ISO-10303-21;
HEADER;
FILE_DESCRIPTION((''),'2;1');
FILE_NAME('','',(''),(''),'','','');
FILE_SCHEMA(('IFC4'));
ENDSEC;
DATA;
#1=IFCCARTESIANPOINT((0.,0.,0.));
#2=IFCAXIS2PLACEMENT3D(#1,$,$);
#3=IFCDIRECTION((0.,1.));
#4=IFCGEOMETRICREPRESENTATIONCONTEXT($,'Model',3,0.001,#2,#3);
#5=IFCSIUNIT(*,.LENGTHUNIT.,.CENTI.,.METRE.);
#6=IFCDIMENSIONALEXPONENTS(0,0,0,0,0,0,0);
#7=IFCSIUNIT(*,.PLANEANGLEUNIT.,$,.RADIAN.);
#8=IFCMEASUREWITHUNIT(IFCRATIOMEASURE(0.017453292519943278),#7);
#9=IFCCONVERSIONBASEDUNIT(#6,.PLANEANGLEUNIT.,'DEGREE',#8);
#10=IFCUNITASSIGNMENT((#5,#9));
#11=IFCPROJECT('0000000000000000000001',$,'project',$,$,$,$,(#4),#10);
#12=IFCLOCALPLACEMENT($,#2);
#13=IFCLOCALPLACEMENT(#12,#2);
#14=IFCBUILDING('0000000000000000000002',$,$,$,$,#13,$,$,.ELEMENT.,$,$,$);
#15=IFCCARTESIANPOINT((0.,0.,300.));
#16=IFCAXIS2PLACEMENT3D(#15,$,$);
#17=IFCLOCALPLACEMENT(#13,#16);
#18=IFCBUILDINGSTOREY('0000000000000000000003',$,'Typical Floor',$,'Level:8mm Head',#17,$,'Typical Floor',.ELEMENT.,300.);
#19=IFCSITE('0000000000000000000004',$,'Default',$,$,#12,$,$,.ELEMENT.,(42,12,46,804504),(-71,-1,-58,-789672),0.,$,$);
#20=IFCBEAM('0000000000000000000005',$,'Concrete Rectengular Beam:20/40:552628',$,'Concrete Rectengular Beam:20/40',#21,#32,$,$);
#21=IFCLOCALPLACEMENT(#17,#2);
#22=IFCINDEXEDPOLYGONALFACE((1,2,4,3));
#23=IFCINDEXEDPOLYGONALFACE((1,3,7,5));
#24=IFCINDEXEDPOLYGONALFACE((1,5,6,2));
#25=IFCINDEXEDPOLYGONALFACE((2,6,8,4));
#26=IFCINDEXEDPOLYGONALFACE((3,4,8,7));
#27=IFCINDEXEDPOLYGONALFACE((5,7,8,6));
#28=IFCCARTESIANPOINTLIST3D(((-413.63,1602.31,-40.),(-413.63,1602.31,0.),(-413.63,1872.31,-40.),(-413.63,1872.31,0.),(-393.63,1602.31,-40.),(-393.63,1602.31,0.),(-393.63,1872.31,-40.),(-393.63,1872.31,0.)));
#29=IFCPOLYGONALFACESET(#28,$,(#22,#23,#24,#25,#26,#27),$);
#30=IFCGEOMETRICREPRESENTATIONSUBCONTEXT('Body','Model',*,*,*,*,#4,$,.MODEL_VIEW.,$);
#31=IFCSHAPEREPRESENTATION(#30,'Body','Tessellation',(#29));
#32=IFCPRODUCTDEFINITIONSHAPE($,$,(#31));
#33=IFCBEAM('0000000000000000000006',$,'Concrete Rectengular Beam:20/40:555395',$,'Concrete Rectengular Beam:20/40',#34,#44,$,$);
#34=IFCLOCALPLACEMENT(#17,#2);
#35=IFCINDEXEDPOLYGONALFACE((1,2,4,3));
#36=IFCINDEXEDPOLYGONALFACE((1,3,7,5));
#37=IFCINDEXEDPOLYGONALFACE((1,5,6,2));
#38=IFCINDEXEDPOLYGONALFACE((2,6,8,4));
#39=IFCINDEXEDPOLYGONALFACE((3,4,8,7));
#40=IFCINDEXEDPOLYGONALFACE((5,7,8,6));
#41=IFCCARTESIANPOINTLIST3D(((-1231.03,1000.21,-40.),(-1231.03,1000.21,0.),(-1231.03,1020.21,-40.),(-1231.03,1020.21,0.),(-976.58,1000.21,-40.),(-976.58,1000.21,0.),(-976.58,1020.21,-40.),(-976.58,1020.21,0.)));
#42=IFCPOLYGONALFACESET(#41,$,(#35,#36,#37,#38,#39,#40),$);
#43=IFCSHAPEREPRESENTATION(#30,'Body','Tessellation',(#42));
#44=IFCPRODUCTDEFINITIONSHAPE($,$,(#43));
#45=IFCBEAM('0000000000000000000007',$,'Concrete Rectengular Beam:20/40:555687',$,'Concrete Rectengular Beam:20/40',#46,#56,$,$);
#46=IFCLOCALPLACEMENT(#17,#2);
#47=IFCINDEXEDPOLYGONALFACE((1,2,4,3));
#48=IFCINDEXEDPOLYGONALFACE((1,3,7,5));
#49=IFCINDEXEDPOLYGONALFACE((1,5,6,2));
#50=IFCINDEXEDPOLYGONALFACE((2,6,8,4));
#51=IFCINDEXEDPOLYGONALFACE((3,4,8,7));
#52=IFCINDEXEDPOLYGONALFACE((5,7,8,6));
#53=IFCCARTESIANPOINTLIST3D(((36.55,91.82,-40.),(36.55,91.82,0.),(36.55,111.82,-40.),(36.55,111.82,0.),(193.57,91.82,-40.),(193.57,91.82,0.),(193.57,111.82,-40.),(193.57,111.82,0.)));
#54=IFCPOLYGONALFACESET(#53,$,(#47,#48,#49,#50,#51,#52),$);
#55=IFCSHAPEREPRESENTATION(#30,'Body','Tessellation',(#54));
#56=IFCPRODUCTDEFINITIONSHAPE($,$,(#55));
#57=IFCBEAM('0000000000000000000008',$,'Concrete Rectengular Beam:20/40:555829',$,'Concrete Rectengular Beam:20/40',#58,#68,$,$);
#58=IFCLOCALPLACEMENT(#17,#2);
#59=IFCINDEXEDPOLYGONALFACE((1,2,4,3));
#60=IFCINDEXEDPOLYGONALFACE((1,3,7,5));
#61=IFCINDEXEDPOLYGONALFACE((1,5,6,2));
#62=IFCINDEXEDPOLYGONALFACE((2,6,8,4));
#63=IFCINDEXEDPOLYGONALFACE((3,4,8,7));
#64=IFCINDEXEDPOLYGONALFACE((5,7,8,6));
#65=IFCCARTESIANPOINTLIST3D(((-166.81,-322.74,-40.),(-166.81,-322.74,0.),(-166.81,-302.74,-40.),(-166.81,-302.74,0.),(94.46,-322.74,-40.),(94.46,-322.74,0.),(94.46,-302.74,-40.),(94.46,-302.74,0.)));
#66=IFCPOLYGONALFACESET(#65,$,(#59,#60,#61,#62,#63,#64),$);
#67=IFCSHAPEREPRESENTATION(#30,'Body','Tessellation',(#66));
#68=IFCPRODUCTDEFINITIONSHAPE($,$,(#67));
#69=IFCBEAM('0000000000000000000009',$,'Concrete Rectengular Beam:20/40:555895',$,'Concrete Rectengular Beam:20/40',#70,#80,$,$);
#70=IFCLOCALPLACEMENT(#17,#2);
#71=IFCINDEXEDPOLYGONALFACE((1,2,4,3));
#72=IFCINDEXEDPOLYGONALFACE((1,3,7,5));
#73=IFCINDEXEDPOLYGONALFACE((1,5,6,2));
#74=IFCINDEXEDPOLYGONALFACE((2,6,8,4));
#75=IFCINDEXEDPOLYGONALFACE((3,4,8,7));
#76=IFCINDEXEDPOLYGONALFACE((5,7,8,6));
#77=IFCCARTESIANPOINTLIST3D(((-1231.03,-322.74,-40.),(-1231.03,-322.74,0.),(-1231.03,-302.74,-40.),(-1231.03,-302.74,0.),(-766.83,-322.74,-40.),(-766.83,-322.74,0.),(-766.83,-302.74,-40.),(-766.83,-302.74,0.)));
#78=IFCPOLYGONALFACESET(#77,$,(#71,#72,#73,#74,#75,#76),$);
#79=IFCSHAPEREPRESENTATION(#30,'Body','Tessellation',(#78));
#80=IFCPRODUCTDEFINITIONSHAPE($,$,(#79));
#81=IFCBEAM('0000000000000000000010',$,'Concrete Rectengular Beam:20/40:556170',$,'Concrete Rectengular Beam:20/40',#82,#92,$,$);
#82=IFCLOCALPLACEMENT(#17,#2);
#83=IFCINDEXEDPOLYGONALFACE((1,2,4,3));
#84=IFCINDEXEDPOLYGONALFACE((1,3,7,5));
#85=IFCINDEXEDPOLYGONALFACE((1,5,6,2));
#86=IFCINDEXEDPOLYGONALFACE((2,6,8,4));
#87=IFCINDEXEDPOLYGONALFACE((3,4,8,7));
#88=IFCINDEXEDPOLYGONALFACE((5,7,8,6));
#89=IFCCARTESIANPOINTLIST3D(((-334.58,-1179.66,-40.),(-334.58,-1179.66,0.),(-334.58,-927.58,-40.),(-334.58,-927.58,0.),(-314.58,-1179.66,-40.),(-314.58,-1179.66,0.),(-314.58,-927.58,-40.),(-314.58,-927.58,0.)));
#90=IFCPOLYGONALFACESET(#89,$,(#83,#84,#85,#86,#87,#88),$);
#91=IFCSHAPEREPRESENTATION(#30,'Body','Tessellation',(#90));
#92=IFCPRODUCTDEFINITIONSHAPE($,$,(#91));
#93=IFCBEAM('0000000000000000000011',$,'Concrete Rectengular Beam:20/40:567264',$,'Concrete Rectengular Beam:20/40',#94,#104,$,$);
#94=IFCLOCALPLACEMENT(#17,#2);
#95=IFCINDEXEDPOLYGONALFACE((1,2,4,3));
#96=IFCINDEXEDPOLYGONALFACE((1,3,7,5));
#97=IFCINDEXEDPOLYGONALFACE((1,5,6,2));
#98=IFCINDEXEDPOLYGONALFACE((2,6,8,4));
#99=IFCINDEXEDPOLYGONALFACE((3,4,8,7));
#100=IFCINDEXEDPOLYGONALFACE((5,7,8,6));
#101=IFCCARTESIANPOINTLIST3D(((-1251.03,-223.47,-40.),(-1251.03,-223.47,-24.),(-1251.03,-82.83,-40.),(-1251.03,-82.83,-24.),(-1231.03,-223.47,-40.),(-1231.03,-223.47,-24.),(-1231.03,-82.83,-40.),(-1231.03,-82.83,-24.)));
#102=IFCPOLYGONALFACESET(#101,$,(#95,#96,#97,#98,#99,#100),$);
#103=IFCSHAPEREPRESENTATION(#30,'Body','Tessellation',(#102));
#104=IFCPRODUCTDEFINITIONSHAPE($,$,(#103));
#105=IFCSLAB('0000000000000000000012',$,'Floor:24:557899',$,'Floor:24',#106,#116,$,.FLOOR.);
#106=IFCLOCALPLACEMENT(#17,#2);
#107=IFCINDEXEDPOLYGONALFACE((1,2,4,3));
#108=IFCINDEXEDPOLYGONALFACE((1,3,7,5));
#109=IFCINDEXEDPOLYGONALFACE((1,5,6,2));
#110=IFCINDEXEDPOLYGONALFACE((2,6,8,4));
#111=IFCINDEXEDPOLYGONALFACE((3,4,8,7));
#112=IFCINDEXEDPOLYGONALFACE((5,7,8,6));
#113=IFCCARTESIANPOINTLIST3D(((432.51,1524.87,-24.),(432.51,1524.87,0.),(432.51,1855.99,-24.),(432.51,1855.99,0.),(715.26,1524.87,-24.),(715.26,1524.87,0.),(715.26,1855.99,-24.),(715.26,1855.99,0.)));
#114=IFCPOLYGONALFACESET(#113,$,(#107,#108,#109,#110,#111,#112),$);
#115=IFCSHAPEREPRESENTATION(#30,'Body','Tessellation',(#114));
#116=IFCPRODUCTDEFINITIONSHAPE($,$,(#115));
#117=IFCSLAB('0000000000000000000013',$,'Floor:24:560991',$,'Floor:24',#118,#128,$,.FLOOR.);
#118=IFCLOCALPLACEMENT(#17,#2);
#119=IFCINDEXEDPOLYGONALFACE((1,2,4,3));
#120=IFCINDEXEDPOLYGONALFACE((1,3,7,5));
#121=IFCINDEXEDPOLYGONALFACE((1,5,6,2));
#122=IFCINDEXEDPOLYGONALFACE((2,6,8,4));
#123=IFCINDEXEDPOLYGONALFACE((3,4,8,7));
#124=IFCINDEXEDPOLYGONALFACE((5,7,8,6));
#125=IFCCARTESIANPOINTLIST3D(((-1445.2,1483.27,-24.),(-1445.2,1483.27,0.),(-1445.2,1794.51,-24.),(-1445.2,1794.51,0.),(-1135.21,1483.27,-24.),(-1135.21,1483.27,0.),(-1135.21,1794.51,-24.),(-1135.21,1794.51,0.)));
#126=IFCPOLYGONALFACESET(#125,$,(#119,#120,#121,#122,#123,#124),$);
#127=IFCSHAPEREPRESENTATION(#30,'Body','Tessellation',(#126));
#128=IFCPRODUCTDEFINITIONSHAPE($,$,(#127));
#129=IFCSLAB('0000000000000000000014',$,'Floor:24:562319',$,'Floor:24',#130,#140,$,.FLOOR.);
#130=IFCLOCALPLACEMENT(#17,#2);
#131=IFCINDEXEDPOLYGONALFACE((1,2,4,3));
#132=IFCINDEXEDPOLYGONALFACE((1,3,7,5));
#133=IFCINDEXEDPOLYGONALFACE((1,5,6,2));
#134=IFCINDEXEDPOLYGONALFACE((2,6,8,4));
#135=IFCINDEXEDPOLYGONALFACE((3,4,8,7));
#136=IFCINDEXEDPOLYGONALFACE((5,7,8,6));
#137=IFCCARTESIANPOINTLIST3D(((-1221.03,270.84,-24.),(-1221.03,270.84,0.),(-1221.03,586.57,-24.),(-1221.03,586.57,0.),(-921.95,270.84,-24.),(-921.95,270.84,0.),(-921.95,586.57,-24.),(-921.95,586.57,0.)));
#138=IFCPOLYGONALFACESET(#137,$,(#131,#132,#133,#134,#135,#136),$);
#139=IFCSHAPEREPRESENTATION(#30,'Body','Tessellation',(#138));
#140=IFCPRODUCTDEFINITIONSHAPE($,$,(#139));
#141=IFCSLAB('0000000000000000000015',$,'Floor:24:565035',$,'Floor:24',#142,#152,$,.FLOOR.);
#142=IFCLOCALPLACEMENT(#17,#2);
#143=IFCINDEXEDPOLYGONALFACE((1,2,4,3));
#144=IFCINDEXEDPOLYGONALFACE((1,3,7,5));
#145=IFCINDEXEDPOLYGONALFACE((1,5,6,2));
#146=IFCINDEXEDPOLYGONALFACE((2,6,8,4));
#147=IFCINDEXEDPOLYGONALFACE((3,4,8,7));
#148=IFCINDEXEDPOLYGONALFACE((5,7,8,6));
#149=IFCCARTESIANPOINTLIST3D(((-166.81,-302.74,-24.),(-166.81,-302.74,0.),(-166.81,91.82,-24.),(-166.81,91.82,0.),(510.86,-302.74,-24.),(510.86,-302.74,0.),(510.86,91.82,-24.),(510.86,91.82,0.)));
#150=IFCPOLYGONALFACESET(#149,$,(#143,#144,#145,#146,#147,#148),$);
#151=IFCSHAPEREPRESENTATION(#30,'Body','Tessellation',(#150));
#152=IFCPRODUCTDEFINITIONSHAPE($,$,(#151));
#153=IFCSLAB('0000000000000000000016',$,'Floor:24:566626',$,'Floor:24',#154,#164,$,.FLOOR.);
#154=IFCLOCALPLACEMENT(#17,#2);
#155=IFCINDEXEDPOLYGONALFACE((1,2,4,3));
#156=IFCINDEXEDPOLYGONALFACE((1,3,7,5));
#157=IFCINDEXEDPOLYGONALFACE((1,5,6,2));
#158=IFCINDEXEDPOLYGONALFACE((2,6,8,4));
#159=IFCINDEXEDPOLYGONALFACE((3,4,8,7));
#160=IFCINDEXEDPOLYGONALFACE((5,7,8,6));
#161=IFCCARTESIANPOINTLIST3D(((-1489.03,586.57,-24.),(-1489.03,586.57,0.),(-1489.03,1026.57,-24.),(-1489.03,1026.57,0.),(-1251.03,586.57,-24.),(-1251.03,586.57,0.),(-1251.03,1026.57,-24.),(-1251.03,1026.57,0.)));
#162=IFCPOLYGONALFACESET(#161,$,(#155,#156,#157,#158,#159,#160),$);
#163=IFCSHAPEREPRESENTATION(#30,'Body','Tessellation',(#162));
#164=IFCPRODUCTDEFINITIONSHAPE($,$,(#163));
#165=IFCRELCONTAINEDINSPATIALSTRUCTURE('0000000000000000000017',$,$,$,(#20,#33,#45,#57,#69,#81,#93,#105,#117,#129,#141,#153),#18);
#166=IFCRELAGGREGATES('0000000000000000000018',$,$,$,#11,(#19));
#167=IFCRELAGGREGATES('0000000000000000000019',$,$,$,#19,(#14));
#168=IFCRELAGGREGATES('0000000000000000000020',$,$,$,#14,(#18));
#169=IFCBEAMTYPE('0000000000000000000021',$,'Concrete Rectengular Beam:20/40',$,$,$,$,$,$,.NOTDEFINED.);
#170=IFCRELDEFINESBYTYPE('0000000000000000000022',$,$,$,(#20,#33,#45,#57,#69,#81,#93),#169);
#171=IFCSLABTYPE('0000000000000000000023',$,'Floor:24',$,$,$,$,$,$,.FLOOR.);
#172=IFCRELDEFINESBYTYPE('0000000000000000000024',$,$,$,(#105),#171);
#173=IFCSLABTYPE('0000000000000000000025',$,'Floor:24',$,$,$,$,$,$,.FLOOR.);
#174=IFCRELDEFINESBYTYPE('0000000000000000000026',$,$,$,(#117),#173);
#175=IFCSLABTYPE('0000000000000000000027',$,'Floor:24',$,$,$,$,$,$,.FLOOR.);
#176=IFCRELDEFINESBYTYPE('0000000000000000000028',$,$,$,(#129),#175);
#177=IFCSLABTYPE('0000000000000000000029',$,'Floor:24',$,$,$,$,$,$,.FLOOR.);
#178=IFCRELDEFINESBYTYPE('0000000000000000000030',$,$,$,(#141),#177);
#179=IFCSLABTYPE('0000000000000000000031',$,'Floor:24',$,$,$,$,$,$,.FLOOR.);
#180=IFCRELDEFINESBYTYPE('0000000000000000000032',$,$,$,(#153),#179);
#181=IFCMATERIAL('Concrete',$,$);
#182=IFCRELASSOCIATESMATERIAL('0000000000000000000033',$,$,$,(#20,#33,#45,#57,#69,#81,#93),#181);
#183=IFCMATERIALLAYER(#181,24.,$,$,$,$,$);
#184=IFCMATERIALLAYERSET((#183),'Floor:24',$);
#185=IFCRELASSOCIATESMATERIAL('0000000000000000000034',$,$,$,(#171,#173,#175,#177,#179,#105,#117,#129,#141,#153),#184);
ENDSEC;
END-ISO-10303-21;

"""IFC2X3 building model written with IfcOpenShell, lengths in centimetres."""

from ifc_helpers import new_model, entity, si_unit, converted_unit, direction, frame, frame_2d, origin, origin_2d_with_axis, place, context, subcontext, project, spatial, rectangle, extrude, material, layer, layer_set, layer_usage, type_object, element, save


model = new_model("IFC2X3")

# Units and contexts
model_context = context("Model", 3, precision=0.001, world=origin(), true_north=direction((0.0, 1.0)))
body_context = subcontext(model_context, "Body", "Model", "MODEL_VIEW")
ifc_project = project(units=[si_unit("LENGTHUNIT", "METRE", prefix="CENTI"), converted_unit("PLANEANGLEUNIT", "DEGREE", entity("IfcRatioMeasure", 0.017453292519943278), si_unit("PLANEANGLEUNIT", "RADIAN"), dimensions=[0, 0, 0, 0, 0, 0, 0])], contexts=[model_context])

# Site, building, storey
site_placement = place(None, origin())
site = spatial("IfcSite", under=ifc_project, at=site_placement, Name="Default", CompositionType="ELEMENT", RefLatitude=(42, 12, 46, 804504), RefLongitude=(-71, -1, -58, -789672), RefElevation=0.0)
building_placement = place(site_placement, origin())
building = spatial("IfcBuilding", under=site, at=building_placement, CompositionType="ELEMENT")
storey_placement = place(building_placement, frame((0.0, 0.0, 300.0)))
storey = spatial("IfcBuildingStorey", under=building, at=storey_placement, Name="Typical Floor", ObjectType="Level:8mm Head", LongName="Typical Floor", CompositionType="ELEMENT", Elevation=300.0)

# Beams
ifc_material = material(Name="Concrete")
beam_type = type_object("IfcBeamType", Name="Concrete Rectengular Beam:20/40", PredefinedType="NOTDEFINED")
beam_1_placement = place(storey_placement, frame((-403.63, 1882.31, 0.0), z_axis=(0.0, 0.0, 1.0), x_axis=(0.0, -1.0, 0.0)))
element("IfcBeam", 1, at=beam_1_placement, inside=storey, type_object=beam_type, material=ifc_material, Name="Concrete Rectengular Beam:20/40:552628", ObjectType="Concrete Rectengular Beam:20/40", context=body_context, shape_type="SweptSolid", body=[
    extrude(rectangle(XDim=40.0, YDim=20.0, at=origin_2d_with_axis()), frame((10.0, 0.0, -20.0), z_axis=(1.0, 0.0, 0.0), x_axis=(0.0, 0.0, -1.0)), (0.0, 0.0, 1.0), 270.0),
])
beam_2_placement = place(storey_placement, frame((-1241.03, 1010.21, 0.0)))
element("IfcBeam", 2, at=beam_2_placement, inside=storey, type_object=beam_type, material=ifc_material, Name="Concrete Rectengular Beam:20/40:555395", ObjectType="Concrete Rectengular Beam:20/40", context=body_context, shape_type="SweptSolid", body=[
    extrude(rectangle(XDim=40.0, YDim=20.0, at=frame_2d((0.0, 0.0), x_axis=(1.0, 0.0))), frame((10.0, 0.0, -20.0), z_axis=(1.0, 0.0, 0.0), x_axis=(0.0, 0.0, -1.0)), (0.0, 0.0, 1.0), 254.45),
])
beam_3_placement = place(storey_placement, frame((26.55, 101.82, 0.0)))
element("IfcBeam", 3, at=beam_3_placement, inside=storey, type_object=beam_type, material=ifc_material, Name="Concrete Rectengular Beam:20/40:555687", ObjectType="Concrete Rectengular Beam:20/40", context=body_context, shape_type="SweptSolid", body=[
    extrude(rectangle(XDim=40.0, YDim=20.0, at=frame_2d((0.0, 0.0), x_axis=(1.0, 0.0))), frame((10.0, 0.0, -20.0), z_axis=(1.0, 0.0, 0.0), x_axis=(0.0, 0.0, -1.0)), (0.0, 0.0, 1.0), 157.01),
])
beam_4_placement = place(storey_placement, frame((-176.81, -312.74, 0.0)))
element("IfcBeam", 4, at=beam_4_placement, inside=storey, type_object=beam_type, material=ifc_material, Name="Concrete Rectengular Beam:20/40:555829", ObjectType="Concrete Rectengular Beam:20/40", context=body_context, shape_type="SweptSolid", body=[
    extrude(rectangle(XDim=40.0, YDim=20.0, at=frame_2d((0.0, 0.0), x_axis=(1.0, 0.0))), frame((10.0, 0.0, -20.0), z_axis=(1.0, 0.0, 0.0), x_axis=(0.0, 0.0, -1.0)), (0.0, 0.0, 1.0), 261.28),
])
beam_5_placement = place(storey_placement, frame((-1241.03, -312.74, 0.0)))
element("IfcBeam", 5, at=beam_5_placement, inside=storey, type_object=beam_type, material=ifc_material, Name="Concrete Rectengular Beam:20/40:555895", ObjectType="Concrete Rectengular Beam:20/40", context=body_context, shape_type="SweptSolid", body=[
    extrude(rectangle(XDim=40.0, YDim=20.0, at=frame_2d((0.0, 0.0), x_axis=(1.0, 0.0))), frame((10.0, 0.0, -20.0), z_axis=(1.0, 0.0, 0.0), x_axis=(0.0, 0.0, -1.0)), (0.0, 0.0, 1.0), 464.2),
])
beam_6_placement = place(storey_placement, frame((-324.58, -1189.66, 0.0), z_axis=(0.0, 0.0, 1.0), x_axis=(0.0, 1.0, 0.0)))
element("IfcBeam", 6, at=beam_6_placement, inside=storey, type_object=beam_type, material=ifc_material, Name="Concrete Rectengular Beam:20/40:556170", ObjectType="Concrete Rectengular Beam:20/40", context=body_context, shape_type="SweptSolid", body=[
    extrude(rectangle(XDim=40.0, YDim=20.0, at=origin_2d_with_axis()), frame((10.0, 0.0, -20.0), z_axis=(1.0, 0.0, 0.0), x_axis=(0.0, 0.0, -1.0)), (0.0, 0.0, 1.0), 252.08),
])
beam_7_placement = place(storey_placement, frame((-1241.03, -233.47, 0.0), z_axis=(0.0, 0.0, 1.0), x_axis=(0.0, 1.0, 0.0)))
element("IfcBeam", 7, at=beam_7_placement, inside=storey, type_object=beam_type, material=ifc_material, Name="Concrete Rectengular Beam:20/40:567264", ObjectType="Concrete Rectengular Beam:20/40", context=body_context, shape_type="SweptSolid", body=[
    extrude(rectangle(XDim=16.0, YDim=20.0, at=frame_2d((0.0, 0.0), x_axis=(1.0, 0.0))), frame((10.0, 0.0, -32.0), z_axis=(1.0, 0.0, 0.0), x_axis=(0.0, 0.0, -1.0)), (0.0, 0.0, 1.0), 140.64),
])

# Slabs
ifc_layer = layer(ifc_material, 24.0)
ifc_layer_set = layer_set([ifc_layer], Name="Floor:24")
ifc_layer_usage_1 = layer_usage(ifc_layer_set, "AXIS3", "POSITIVE", 0.0)
slab_type_1 = type_object("IfcSlabType", Name="Floor:24", PredefinedType="FLOOR", material=ifc_layer_set)
slab_1_placement = place(storey_placement, origin())
element("IfcSlab", 8, at=slab_1_placement, inside=storey, type_object=slab_type_1, material=ifc_layer_usage_1, Name="Floor:24:557899", ObjectType="Floor:24", PredefinedType="FLOOR", context=body_context, shape_type="SweptSolid", body=[
    extrude(rectangle(XDim=331.12, YDim=282.75, at=frame_2d((0.0, 0.0), x_axis=(1.0, 0.0))), frame((573.88, 1690.43, 0.0), z_axis=(0.0, 0.0, -1.0), x_axis=(0.0, 1.0, 0.0)), (0.0, 0.0, 1.0), 24.0),
])
ifc_layer_usage_2 = layer_usage(ifc_layer_set, "AXIS3", "POSITIVE", 0.0)
slab_type_2 = type_object("IfcSlabType", Name="Floor:24", PredefinedType="FLOOR", material=ifc_layer_set)
slab_2_placement = place(storey_placement, origin())
element("IfcSlab", 9, at=slab_2_placement, inside=storey, type_object=slab_type_2, material=ifc_layer_usage_2, Name="Floor:24:560991", ObjectType="Floor:24", PredefinedType="FLOOR", context=body_context, shape_type="SweptSolid", body=[
    extrude(rectangle(XDim=311.25, YDim=309.99, at=frame_2d((0.0, 0.0), x_axis=(1.0, 0.0))), frame((-1290.2, 1638.89, 0.0), z_axis=(0.0, 0.0, -1.0), x_axis=(0.0, 1.0, 0.0)), (0.0, 0.0, 1.0), 24.0),
])
ifc_layer_usage_3 = layer_usage(ifc_layer_set, "AXIS3", "POSITIVE", 0.0)
slab_type_3 = type_object("IfcSlabType", Name="Floor:24", PredefinedType="FLOOR", material=ifc_layer_set)
slab_3_placement = place(storey_placement, origin())
element("IfcSlab", 10, at=slab_3_placement, inside=storey, type_object=slab_type_3, material=ifc_layer_usage_3, Name="Floor:24:562319", ObjectType="Floor:24", PredefinedType="FLOOR", context=body_context, shape_type="SweptSolid", body=[
    extrude(rectangle(XDim=315.73, YDim=299.07, at=frame_2d((0.0, 0.0), x_axis=(1.0, 0.0))), frame((-1071.49, 428.71, 0.0), z_axis=(0.0, 0.0, -1.0), x_axis=(0.0, 1.0, 0.0)), (0.0, 0.0, 1.0), 24.0),
])
ifc_layer_usage_4 = layer_usage(ifc_layer_set, "AXIS3", "POSITIVE", 0.0)
slab_type_4 = type_object("IfcSlabType", Name="Floor:24", PredefinedType="FLOOR", material=ifc_layer_set)
slab_4_placement = place(storey_placement, origin())
element("IfcSlab", 11, at=slab_4_placement, inside=storey, type_object=slab_type_4, material=ifc_layer_usage_4, Name="Floor:24:565035", ObjectType="Floor:24", PredefinedType="FLOOR", context=body_context, shape_type="SweptSolid", body=[
    extrude(rectangle(XDim=394.56, YDim=677.67, at=origin_2d_with_axis()), frame((172.02, -105.46, 0.0), z_axis=(0.0, 0.0, -1.0), x_axis=(0.0, 1.0, 0.0)), (0.0, 0.0, 1.0), 24.0),
])
ifc_layer_usage_5 = layer_usage(ifc_layer_set, "AXIS3", "POSITIVE", 0.0)
slab_type_5 = type_object("IfcSlabType", Name="Floor:24", PredefinedType="FLOOR", material=ifc_layer_set)
slab_5_placement = place(storey_placement, origin())
element("IfcSlab", 12, at=slab_5_placement, inside=storey, type_object=slab_type_5, material=ifc_layer_usage_5, Name="Floor:24:566626", ObjectType="Floor:24", PredefinedType="FLOOR", context=body_context, shape_type="SweptSolid", body=[
    extrude(rectangle(XDim=440.0, YDim=238.0, at=frame_2d((0.0, 0.0), x_axis=(1.0, 0.0))), frame((-1370.03, 806.57, 0.0), z_axis=(0.0, 0.0, -1.0), x_axis=(0.0, 1.0, 0.0)), (0.0, 0.0, 1.0), 24.0),
])

save(model, "model.ifc")
